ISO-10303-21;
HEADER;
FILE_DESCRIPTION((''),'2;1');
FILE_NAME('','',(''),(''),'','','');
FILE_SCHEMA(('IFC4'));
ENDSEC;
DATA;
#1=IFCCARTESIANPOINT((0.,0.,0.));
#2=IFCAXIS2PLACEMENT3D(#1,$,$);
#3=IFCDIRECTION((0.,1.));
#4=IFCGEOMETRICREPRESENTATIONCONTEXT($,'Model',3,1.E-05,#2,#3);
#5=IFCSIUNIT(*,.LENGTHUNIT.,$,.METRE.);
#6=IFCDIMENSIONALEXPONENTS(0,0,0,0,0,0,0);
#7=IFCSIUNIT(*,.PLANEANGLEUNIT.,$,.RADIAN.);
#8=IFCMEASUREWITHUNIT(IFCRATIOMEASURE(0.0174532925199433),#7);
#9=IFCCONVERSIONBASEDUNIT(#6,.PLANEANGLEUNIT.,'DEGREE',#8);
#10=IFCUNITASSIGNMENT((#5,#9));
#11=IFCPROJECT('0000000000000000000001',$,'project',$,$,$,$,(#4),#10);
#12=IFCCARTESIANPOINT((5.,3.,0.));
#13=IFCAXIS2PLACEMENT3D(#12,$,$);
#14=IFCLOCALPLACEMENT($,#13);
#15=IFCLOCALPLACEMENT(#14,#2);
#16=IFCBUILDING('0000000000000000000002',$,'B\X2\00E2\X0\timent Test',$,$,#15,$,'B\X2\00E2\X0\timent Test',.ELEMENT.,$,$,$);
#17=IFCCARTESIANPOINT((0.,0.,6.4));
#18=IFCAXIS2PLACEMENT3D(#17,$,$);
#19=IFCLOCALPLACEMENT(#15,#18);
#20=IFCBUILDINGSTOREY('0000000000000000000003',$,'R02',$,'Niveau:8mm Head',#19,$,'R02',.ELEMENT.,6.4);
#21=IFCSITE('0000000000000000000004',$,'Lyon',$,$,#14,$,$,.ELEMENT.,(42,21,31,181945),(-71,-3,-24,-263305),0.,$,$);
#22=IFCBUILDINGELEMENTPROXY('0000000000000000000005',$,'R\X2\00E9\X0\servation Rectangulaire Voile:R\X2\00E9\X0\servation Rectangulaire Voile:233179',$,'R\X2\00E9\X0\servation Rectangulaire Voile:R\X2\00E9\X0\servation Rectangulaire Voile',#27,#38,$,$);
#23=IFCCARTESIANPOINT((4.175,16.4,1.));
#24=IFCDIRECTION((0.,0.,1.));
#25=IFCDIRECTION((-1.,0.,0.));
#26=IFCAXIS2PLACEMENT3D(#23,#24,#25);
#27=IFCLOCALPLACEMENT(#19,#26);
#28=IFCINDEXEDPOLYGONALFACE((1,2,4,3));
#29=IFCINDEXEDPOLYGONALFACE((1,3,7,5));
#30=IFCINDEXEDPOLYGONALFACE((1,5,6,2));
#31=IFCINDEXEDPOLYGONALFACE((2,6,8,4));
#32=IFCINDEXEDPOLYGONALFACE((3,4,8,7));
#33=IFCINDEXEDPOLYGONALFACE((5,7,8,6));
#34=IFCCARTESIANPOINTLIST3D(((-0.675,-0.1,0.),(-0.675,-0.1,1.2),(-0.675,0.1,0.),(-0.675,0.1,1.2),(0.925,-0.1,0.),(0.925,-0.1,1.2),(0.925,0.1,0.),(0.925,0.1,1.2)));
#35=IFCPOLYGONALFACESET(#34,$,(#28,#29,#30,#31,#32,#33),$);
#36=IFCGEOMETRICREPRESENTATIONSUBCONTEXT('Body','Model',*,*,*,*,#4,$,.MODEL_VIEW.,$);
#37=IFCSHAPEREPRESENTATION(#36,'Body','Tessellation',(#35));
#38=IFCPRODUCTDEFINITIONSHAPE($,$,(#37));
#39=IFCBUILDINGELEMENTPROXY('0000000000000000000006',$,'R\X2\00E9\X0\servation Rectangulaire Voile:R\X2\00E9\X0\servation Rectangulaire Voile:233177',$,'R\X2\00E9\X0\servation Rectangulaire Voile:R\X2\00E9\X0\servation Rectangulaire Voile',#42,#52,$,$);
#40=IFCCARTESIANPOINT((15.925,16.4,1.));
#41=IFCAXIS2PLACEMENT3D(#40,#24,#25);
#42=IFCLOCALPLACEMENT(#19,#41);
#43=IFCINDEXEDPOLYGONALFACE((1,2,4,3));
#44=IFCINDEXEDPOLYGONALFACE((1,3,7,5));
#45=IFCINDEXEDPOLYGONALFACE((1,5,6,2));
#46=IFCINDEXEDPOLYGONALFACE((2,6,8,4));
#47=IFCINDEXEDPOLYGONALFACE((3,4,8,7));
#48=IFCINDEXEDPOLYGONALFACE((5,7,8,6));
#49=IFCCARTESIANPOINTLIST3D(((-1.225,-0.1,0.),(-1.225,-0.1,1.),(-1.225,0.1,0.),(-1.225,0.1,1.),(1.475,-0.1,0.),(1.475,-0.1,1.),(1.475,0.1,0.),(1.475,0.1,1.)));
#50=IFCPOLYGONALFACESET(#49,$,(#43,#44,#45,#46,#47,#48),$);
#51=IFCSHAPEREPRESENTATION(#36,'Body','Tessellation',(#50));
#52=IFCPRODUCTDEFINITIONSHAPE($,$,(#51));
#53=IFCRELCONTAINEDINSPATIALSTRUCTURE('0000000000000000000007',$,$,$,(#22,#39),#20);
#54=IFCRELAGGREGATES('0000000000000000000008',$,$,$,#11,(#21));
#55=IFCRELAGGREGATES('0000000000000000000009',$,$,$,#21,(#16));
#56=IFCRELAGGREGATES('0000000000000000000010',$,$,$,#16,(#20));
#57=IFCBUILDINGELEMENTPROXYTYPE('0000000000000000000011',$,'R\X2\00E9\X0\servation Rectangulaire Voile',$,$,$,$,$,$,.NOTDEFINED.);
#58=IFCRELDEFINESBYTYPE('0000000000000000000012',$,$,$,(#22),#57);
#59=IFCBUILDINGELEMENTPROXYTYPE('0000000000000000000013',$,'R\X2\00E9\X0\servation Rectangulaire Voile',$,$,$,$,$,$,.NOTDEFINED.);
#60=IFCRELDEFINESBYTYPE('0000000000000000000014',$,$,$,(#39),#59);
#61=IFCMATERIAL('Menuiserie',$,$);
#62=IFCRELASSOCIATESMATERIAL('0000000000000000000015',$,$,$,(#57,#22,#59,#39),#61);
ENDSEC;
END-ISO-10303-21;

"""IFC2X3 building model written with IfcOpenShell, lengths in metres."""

from ifc_helpers import new_model, entity, si_unit, converted_unit, direction, frame, origin, origin_2d_with_axis, place, context, subcontext, project, spatial, rectangle, extrude, source, transform, mapped, material, type_object, type_shapes, element, save


model = new_model("IFC2X3")

# Units and contexts
model_context = context("Model", 3, precision=1e-05, world=origin(), true_north=direction((0.0, 1.0)))
body_context = subcontext(model_context, "Body", "Model", "MODEL_VIEW")
ifc_project = project(units=[si_unit("LENGTHUNIT", "METRE"), converted_unit("PLANEANGLEUNIT", "DEGREE", entity("IfcRatioMeasure", 0.0174532925199433), si_unit("PLANEANGLEUNIT", "RADIAN"), dimensions=[0, 0, 0, 0, 0, 0, 0])], contexts=[model_context])

# Site, building, storey
site_placement = place(None, frame((5.0, 3.0, 0.0)))
site = spatial("IfcSite", under=ifc_project, at=site_placement, Name="Lyon", CompositionType="ELEMENT", RefLatitude=(42, 21, 31, 181945), RefLongitude=(-71, -3, -24, -263305), RefElevation=0.0)
building_placement = place(site_placement, origin())
building = spatial("IfcBuilding", under=site, at=building_placement, Name="Bâtiment Test", LongName="Bâtiment Test", CompositionType="ELEMENT")
storey_placement = place(building_placement, frame((0.0, 0.0, 6.4)))
storey = spatial("IfcBuildingStorey", under=building, at=storey_placement, Name="R02", ObjectType="Niveau:8mm Head", LongName="R02", CompositionType="ELEMENT", Elevation=6.4)

# Building element proxies
ifc_material_1 = material(Name="Menuiserie")
building_element_proxy_type_1 = type_object("IfcBuildingElementProxyType", Name="Réservation Rectangulaire Voile", PredefinedType="NOTDEFINED", material=ifc_material_1)
shared_shape_1 = source(origin(), body_context, "Body", "SweptSolid", [
    extrude(rectangle(XDim=0.2, YDim=1.6, at=origin_2d_with_axis()), frame((0.125, 0.0, 0.0), z_axis=(0.0, 0.0, 1.0), x_axis=(0.0, 1.0, 0.0)), (0.0, 0.0, 1.0), 1.2),
])
type_shapes(building_element_proxy_type_1, [shared_shape_1])
for number, where, z_axis, x_axis, name in (
    (1, (4.175, 16.4, 1.0), (0.0, 0.0, 1.0), (-1.0, 0.0, 0.0), "Réservation Rectangulaire Voile:Réservation Rectangulaire Voile:233179"),
):
    element("IfcBuildingElementProxy", number, at=place(storey_placement, frame(where, z_axis=z_axis, x_axis=x_axis)), inside=storey, type_object=building_element_proxy_type_1, material=ifc_material_1, Name=name, ObjectType="Réservation Rectangulaire Voile:Réservation Rectangulaire Voile", context=body_context, shape_type="MappedRepresentation", body=[
        mapped(shared_shape_1, transform((0.0, 0.0, 0.0), scale=1.0)),
    ])
building_element_proxy_type_2 = type_object("IfcBuildingElementProxyType", Name="Réservation Rectangulaire Voile", PredefinedType="NOTDEFINED", material=ifc_material_1)
shared_shape_2 = source(origin(), body_context, "Body", "SweptSolid", [
    extrude(rectangle(XDim=0.2, YDim=2.7, at=origin_2d_with_axis()), frame((0.125, 0.0, 0.0), z_axis=(0.0, 0.0, 1.0), x_axis=(0.0, 1.0, 0.0)), (0.0, 0.0, 1.0), 1.0),
])
type_shapes(building_element_proxy_type_2, [shared_shape_2])
proxy_1_placement = place(storey_placement, frame((15.925, 16.4, 1.0), z_axis=(0.0, 0.0, 1.0), x_axis=(-1.0, 0.0, 0.0)))
element("IfcBuildingElementProxy", 2, at=proxy_1_placement, inside=storey, type_object=building_element_proxy_type_2, material=ifc_material_1, Name="Réservation Rectangulaire Voile:Réservation Rectangulaire Voile:233177", ObjectType="Réservation Rectangulaire Voile:Réservation Rectangulaire Voile", context=body_context, shape_type="MappedRepresentation", body=[
    mapped(shared_shape_2, transform((0.0, 0.0, 0.0), scale=1.0)),
])

save(model, "model.ifc")
